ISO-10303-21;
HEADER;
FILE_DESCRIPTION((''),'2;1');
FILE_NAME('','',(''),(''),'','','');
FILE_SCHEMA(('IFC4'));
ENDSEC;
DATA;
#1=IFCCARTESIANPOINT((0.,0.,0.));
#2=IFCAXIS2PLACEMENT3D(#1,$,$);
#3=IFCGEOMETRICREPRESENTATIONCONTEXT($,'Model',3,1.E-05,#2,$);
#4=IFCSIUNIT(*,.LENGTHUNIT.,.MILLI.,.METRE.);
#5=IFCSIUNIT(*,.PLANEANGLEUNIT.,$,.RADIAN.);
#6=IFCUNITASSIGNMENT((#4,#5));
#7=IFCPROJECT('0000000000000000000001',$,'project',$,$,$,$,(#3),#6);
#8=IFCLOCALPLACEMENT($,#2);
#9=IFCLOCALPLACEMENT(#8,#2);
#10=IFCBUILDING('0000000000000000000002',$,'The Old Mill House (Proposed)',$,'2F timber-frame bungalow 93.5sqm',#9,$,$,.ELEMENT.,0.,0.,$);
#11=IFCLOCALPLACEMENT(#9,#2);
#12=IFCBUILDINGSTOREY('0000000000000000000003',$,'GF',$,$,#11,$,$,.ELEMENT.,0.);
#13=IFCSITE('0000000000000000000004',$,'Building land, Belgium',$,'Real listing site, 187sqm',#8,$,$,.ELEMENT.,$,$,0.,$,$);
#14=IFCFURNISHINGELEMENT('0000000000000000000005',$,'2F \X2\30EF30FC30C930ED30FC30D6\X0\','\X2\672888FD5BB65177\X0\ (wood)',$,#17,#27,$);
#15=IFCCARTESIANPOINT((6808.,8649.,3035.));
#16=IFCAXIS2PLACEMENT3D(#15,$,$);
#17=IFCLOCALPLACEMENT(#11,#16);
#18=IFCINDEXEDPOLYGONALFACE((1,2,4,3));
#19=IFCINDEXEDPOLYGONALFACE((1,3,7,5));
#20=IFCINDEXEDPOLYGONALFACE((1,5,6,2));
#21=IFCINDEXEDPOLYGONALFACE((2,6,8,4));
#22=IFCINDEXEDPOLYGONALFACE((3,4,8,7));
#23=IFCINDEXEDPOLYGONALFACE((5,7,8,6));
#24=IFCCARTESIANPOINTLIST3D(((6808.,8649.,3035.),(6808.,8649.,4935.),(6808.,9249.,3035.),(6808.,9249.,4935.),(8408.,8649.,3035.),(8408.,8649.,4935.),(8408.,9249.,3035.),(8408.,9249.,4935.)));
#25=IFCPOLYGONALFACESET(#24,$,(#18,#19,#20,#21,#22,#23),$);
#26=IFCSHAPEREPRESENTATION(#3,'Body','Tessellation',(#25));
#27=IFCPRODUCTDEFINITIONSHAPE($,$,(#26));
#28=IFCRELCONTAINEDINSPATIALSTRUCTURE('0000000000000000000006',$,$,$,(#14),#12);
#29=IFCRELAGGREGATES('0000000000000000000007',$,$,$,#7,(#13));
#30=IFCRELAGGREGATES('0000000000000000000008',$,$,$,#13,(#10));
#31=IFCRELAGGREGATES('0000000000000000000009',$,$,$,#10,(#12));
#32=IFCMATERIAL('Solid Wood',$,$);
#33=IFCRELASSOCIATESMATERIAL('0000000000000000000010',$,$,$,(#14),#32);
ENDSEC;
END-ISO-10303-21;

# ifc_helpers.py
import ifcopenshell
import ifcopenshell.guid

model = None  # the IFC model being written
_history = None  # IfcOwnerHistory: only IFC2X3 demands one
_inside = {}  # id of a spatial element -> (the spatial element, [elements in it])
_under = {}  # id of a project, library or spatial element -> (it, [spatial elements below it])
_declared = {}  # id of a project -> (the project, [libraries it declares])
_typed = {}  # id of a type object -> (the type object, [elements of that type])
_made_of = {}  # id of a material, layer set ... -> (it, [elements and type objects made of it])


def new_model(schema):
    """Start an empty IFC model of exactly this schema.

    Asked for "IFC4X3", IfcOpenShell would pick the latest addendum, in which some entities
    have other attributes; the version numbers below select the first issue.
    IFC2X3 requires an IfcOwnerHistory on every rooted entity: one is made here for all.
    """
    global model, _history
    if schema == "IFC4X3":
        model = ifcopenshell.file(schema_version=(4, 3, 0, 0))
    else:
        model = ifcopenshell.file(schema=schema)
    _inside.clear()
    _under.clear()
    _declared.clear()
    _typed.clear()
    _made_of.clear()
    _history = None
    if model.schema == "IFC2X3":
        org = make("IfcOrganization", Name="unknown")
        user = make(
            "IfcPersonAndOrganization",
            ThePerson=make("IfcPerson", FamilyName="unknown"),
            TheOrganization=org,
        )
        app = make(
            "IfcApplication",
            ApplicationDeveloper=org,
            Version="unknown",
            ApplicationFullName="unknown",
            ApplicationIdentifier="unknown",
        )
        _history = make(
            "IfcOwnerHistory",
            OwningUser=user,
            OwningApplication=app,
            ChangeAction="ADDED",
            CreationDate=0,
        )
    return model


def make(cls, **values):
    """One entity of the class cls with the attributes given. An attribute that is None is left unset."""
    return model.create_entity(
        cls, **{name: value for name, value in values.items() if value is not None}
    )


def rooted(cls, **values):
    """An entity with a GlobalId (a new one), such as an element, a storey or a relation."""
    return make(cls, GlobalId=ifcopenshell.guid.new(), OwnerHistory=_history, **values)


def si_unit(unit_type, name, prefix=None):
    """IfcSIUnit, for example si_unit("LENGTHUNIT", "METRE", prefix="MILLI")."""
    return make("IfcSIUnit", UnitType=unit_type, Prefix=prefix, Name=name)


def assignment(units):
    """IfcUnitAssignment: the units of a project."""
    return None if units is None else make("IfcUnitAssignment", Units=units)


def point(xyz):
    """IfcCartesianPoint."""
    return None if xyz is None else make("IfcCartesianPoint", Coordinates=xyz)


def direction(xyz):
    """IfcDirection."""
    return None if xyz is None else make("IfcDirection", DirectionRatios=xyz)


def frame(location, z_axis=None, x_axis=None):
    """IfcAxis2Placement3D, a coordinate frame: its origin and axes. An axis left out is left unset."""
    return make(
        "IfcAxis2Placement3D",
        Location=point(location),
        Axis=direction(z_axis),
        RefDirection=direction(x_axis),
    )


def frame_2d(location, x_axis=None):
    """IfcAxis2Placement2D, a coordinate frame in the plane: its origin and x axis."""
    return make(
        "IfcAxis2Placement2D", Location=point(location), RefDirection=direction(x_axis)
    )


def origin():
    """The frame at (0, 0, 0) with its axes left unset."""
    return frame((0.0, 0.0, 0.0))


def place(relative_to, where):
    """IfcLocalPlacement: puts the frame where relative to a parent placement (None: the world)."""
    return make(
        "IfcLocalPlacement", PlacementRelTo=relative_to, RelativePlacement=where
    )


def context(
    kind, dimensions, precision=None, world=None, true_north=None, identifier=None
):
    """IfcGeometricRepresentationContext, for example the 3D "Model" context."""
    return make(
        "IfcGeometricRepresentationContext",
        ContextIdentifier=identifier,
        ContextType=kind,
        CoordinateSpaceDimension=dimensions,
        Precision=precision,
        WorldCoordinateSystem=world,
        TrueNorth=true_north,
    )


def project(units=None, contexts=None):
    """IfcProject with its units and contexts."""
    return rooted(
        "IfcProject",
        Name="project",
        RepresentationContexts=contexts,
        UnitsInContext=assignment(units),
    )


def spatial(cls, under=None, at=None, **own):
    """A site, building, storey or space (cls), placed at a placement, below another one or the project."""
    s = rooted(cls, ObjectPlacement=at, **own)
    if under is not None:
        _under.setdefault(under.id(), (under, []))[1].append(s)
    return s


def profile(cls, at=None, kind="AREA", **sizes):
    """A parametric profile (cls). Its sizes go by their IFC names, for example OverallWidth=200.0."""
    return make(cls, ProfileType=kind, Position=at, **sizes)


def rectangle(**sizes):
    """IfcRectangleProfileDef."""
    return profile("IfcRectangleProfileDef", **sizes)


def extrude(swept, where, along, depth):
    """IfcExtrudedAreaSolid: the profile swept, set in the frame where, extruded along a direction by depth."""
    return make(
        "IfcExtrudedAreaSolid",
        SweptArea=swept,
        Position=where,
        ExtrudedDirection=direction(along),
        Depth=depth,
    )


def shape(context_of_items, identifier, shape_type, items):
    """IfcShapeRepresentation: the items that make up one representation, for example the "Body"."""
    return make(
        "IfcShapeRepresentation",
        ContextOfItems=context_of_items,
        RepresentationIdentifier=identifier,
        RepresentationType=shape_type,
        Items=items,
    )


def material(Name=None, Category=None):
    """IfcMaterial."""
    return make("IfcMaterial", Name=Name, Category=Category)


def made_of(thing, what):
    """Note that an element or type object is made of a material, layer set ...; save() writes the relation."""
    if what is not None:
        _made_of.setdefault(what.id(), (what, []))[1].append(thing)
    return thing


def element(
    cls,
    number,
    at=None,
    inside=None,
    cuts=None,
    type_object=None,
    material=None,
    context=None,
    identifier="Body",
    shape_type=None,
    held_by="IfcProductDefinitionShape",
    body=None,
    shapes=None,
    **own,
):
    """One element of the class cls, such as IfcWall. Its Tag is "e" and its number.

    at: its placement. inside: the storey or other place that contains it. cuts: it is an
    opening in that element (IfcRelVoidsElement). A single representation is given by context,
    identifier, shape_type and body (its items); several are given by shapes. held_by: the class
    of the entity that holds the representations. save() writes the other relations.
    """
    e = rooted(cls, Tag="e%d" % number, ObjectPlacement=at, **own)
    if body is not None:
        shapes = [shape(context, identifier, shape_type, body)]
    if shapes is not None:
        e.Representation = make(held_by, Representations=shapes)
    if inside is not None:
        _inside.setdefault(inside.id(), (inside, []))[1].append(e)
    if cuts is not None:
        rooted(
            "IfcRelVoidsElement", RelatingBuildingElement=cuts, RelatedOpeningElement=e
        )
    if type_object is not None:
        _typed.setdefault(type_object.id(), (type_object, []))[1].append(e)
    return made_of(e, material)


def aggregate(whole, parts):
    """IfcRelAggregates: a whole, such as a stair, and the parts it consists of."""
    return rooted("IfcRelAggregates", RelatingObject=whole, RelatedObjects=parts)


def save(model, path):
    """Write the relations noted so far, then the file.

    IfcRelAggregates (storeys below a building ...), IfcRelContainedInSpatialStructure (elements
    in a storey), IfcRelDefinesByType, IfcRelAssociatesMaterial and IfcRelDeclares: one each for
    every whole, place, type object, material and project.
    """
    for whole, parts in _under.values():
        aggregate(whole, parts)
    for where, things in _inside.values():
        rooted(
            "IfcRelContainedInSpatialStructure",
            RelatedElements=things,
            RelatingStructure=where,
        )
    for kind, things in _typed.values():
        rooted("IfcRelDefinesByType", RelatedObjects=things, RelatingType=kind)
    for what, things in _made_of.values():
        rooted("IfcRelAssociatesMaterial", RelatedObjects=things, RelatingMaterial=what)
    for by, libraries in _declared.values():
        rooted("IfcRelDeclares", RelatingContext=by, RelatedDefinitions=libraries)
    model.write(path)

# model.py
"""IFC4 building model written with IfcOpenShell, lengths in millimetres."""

from ifc_helpers import new_model, si_unit, frame, frame_2d, origin, place, context, project, spatial, rectangle, extrude, material, element, save


model = new_model("IFC4")

# Units and contexts
model_context = context("Model", 3, precision=1e-05, world=origin())
ifc_project = project(units=[si_unit("LENGTHUNIT", "METRE", prefix="MILLI"), si_unit("PLANEANGLEUNIT", "RADIAN")], contexts=[model_context])

# Site, building, storey
site_placement = place(None, origin())
site = spatial("IfcSite", under=ifc_project, at=site_placement, Name="Building land, Belgium", ObjectType="Real listing site, 187sqm", CompositionType="ELEMENT", RefElevation=0.0)
building_placement = place(site_placement, origin())
building = spatial("IfcBuilding", under=site, at=building_placement, Name="The Old Mill House (Proposed)", ObjectType="2F timber-frame bungalow 93.5sqm", CompositionType="ELEMENT", ElevationOfRefHeight=0.0, ElevationOfTerrain=0.0)
storey_placement = place(building_placement, origin())
storey = spatial("IfcBuildingStorey", under=building, at=storey_placement, Name="GF", CompositionType="ELEMENT", Elevation=0.0)

# Shared definitions
ifc_material_1 = material(Name="Solid Wood")

# Furnishing element
furnishing_1_placement = place(storey_placement, frame((6808.0, 8649.0, 3035.0)))
element("IfcFurnishingElement", 1, at=furnishing_1_placement, inside=storey, material=ifc_material_1, Name="2F ワードローブ", Description="木製家具 (wood)", context=model_context, shape_type="SweptSolid", body=[
    extrude(rectangle(XDim=1600.0, YDim=600.0, at=frame_2d((800.0, 300.0))), frame((6808.0, 8649.0, 3035.0)), (0.0, 0.0, 1.0), 1900.0),
])

save(model, "model.ifc")
